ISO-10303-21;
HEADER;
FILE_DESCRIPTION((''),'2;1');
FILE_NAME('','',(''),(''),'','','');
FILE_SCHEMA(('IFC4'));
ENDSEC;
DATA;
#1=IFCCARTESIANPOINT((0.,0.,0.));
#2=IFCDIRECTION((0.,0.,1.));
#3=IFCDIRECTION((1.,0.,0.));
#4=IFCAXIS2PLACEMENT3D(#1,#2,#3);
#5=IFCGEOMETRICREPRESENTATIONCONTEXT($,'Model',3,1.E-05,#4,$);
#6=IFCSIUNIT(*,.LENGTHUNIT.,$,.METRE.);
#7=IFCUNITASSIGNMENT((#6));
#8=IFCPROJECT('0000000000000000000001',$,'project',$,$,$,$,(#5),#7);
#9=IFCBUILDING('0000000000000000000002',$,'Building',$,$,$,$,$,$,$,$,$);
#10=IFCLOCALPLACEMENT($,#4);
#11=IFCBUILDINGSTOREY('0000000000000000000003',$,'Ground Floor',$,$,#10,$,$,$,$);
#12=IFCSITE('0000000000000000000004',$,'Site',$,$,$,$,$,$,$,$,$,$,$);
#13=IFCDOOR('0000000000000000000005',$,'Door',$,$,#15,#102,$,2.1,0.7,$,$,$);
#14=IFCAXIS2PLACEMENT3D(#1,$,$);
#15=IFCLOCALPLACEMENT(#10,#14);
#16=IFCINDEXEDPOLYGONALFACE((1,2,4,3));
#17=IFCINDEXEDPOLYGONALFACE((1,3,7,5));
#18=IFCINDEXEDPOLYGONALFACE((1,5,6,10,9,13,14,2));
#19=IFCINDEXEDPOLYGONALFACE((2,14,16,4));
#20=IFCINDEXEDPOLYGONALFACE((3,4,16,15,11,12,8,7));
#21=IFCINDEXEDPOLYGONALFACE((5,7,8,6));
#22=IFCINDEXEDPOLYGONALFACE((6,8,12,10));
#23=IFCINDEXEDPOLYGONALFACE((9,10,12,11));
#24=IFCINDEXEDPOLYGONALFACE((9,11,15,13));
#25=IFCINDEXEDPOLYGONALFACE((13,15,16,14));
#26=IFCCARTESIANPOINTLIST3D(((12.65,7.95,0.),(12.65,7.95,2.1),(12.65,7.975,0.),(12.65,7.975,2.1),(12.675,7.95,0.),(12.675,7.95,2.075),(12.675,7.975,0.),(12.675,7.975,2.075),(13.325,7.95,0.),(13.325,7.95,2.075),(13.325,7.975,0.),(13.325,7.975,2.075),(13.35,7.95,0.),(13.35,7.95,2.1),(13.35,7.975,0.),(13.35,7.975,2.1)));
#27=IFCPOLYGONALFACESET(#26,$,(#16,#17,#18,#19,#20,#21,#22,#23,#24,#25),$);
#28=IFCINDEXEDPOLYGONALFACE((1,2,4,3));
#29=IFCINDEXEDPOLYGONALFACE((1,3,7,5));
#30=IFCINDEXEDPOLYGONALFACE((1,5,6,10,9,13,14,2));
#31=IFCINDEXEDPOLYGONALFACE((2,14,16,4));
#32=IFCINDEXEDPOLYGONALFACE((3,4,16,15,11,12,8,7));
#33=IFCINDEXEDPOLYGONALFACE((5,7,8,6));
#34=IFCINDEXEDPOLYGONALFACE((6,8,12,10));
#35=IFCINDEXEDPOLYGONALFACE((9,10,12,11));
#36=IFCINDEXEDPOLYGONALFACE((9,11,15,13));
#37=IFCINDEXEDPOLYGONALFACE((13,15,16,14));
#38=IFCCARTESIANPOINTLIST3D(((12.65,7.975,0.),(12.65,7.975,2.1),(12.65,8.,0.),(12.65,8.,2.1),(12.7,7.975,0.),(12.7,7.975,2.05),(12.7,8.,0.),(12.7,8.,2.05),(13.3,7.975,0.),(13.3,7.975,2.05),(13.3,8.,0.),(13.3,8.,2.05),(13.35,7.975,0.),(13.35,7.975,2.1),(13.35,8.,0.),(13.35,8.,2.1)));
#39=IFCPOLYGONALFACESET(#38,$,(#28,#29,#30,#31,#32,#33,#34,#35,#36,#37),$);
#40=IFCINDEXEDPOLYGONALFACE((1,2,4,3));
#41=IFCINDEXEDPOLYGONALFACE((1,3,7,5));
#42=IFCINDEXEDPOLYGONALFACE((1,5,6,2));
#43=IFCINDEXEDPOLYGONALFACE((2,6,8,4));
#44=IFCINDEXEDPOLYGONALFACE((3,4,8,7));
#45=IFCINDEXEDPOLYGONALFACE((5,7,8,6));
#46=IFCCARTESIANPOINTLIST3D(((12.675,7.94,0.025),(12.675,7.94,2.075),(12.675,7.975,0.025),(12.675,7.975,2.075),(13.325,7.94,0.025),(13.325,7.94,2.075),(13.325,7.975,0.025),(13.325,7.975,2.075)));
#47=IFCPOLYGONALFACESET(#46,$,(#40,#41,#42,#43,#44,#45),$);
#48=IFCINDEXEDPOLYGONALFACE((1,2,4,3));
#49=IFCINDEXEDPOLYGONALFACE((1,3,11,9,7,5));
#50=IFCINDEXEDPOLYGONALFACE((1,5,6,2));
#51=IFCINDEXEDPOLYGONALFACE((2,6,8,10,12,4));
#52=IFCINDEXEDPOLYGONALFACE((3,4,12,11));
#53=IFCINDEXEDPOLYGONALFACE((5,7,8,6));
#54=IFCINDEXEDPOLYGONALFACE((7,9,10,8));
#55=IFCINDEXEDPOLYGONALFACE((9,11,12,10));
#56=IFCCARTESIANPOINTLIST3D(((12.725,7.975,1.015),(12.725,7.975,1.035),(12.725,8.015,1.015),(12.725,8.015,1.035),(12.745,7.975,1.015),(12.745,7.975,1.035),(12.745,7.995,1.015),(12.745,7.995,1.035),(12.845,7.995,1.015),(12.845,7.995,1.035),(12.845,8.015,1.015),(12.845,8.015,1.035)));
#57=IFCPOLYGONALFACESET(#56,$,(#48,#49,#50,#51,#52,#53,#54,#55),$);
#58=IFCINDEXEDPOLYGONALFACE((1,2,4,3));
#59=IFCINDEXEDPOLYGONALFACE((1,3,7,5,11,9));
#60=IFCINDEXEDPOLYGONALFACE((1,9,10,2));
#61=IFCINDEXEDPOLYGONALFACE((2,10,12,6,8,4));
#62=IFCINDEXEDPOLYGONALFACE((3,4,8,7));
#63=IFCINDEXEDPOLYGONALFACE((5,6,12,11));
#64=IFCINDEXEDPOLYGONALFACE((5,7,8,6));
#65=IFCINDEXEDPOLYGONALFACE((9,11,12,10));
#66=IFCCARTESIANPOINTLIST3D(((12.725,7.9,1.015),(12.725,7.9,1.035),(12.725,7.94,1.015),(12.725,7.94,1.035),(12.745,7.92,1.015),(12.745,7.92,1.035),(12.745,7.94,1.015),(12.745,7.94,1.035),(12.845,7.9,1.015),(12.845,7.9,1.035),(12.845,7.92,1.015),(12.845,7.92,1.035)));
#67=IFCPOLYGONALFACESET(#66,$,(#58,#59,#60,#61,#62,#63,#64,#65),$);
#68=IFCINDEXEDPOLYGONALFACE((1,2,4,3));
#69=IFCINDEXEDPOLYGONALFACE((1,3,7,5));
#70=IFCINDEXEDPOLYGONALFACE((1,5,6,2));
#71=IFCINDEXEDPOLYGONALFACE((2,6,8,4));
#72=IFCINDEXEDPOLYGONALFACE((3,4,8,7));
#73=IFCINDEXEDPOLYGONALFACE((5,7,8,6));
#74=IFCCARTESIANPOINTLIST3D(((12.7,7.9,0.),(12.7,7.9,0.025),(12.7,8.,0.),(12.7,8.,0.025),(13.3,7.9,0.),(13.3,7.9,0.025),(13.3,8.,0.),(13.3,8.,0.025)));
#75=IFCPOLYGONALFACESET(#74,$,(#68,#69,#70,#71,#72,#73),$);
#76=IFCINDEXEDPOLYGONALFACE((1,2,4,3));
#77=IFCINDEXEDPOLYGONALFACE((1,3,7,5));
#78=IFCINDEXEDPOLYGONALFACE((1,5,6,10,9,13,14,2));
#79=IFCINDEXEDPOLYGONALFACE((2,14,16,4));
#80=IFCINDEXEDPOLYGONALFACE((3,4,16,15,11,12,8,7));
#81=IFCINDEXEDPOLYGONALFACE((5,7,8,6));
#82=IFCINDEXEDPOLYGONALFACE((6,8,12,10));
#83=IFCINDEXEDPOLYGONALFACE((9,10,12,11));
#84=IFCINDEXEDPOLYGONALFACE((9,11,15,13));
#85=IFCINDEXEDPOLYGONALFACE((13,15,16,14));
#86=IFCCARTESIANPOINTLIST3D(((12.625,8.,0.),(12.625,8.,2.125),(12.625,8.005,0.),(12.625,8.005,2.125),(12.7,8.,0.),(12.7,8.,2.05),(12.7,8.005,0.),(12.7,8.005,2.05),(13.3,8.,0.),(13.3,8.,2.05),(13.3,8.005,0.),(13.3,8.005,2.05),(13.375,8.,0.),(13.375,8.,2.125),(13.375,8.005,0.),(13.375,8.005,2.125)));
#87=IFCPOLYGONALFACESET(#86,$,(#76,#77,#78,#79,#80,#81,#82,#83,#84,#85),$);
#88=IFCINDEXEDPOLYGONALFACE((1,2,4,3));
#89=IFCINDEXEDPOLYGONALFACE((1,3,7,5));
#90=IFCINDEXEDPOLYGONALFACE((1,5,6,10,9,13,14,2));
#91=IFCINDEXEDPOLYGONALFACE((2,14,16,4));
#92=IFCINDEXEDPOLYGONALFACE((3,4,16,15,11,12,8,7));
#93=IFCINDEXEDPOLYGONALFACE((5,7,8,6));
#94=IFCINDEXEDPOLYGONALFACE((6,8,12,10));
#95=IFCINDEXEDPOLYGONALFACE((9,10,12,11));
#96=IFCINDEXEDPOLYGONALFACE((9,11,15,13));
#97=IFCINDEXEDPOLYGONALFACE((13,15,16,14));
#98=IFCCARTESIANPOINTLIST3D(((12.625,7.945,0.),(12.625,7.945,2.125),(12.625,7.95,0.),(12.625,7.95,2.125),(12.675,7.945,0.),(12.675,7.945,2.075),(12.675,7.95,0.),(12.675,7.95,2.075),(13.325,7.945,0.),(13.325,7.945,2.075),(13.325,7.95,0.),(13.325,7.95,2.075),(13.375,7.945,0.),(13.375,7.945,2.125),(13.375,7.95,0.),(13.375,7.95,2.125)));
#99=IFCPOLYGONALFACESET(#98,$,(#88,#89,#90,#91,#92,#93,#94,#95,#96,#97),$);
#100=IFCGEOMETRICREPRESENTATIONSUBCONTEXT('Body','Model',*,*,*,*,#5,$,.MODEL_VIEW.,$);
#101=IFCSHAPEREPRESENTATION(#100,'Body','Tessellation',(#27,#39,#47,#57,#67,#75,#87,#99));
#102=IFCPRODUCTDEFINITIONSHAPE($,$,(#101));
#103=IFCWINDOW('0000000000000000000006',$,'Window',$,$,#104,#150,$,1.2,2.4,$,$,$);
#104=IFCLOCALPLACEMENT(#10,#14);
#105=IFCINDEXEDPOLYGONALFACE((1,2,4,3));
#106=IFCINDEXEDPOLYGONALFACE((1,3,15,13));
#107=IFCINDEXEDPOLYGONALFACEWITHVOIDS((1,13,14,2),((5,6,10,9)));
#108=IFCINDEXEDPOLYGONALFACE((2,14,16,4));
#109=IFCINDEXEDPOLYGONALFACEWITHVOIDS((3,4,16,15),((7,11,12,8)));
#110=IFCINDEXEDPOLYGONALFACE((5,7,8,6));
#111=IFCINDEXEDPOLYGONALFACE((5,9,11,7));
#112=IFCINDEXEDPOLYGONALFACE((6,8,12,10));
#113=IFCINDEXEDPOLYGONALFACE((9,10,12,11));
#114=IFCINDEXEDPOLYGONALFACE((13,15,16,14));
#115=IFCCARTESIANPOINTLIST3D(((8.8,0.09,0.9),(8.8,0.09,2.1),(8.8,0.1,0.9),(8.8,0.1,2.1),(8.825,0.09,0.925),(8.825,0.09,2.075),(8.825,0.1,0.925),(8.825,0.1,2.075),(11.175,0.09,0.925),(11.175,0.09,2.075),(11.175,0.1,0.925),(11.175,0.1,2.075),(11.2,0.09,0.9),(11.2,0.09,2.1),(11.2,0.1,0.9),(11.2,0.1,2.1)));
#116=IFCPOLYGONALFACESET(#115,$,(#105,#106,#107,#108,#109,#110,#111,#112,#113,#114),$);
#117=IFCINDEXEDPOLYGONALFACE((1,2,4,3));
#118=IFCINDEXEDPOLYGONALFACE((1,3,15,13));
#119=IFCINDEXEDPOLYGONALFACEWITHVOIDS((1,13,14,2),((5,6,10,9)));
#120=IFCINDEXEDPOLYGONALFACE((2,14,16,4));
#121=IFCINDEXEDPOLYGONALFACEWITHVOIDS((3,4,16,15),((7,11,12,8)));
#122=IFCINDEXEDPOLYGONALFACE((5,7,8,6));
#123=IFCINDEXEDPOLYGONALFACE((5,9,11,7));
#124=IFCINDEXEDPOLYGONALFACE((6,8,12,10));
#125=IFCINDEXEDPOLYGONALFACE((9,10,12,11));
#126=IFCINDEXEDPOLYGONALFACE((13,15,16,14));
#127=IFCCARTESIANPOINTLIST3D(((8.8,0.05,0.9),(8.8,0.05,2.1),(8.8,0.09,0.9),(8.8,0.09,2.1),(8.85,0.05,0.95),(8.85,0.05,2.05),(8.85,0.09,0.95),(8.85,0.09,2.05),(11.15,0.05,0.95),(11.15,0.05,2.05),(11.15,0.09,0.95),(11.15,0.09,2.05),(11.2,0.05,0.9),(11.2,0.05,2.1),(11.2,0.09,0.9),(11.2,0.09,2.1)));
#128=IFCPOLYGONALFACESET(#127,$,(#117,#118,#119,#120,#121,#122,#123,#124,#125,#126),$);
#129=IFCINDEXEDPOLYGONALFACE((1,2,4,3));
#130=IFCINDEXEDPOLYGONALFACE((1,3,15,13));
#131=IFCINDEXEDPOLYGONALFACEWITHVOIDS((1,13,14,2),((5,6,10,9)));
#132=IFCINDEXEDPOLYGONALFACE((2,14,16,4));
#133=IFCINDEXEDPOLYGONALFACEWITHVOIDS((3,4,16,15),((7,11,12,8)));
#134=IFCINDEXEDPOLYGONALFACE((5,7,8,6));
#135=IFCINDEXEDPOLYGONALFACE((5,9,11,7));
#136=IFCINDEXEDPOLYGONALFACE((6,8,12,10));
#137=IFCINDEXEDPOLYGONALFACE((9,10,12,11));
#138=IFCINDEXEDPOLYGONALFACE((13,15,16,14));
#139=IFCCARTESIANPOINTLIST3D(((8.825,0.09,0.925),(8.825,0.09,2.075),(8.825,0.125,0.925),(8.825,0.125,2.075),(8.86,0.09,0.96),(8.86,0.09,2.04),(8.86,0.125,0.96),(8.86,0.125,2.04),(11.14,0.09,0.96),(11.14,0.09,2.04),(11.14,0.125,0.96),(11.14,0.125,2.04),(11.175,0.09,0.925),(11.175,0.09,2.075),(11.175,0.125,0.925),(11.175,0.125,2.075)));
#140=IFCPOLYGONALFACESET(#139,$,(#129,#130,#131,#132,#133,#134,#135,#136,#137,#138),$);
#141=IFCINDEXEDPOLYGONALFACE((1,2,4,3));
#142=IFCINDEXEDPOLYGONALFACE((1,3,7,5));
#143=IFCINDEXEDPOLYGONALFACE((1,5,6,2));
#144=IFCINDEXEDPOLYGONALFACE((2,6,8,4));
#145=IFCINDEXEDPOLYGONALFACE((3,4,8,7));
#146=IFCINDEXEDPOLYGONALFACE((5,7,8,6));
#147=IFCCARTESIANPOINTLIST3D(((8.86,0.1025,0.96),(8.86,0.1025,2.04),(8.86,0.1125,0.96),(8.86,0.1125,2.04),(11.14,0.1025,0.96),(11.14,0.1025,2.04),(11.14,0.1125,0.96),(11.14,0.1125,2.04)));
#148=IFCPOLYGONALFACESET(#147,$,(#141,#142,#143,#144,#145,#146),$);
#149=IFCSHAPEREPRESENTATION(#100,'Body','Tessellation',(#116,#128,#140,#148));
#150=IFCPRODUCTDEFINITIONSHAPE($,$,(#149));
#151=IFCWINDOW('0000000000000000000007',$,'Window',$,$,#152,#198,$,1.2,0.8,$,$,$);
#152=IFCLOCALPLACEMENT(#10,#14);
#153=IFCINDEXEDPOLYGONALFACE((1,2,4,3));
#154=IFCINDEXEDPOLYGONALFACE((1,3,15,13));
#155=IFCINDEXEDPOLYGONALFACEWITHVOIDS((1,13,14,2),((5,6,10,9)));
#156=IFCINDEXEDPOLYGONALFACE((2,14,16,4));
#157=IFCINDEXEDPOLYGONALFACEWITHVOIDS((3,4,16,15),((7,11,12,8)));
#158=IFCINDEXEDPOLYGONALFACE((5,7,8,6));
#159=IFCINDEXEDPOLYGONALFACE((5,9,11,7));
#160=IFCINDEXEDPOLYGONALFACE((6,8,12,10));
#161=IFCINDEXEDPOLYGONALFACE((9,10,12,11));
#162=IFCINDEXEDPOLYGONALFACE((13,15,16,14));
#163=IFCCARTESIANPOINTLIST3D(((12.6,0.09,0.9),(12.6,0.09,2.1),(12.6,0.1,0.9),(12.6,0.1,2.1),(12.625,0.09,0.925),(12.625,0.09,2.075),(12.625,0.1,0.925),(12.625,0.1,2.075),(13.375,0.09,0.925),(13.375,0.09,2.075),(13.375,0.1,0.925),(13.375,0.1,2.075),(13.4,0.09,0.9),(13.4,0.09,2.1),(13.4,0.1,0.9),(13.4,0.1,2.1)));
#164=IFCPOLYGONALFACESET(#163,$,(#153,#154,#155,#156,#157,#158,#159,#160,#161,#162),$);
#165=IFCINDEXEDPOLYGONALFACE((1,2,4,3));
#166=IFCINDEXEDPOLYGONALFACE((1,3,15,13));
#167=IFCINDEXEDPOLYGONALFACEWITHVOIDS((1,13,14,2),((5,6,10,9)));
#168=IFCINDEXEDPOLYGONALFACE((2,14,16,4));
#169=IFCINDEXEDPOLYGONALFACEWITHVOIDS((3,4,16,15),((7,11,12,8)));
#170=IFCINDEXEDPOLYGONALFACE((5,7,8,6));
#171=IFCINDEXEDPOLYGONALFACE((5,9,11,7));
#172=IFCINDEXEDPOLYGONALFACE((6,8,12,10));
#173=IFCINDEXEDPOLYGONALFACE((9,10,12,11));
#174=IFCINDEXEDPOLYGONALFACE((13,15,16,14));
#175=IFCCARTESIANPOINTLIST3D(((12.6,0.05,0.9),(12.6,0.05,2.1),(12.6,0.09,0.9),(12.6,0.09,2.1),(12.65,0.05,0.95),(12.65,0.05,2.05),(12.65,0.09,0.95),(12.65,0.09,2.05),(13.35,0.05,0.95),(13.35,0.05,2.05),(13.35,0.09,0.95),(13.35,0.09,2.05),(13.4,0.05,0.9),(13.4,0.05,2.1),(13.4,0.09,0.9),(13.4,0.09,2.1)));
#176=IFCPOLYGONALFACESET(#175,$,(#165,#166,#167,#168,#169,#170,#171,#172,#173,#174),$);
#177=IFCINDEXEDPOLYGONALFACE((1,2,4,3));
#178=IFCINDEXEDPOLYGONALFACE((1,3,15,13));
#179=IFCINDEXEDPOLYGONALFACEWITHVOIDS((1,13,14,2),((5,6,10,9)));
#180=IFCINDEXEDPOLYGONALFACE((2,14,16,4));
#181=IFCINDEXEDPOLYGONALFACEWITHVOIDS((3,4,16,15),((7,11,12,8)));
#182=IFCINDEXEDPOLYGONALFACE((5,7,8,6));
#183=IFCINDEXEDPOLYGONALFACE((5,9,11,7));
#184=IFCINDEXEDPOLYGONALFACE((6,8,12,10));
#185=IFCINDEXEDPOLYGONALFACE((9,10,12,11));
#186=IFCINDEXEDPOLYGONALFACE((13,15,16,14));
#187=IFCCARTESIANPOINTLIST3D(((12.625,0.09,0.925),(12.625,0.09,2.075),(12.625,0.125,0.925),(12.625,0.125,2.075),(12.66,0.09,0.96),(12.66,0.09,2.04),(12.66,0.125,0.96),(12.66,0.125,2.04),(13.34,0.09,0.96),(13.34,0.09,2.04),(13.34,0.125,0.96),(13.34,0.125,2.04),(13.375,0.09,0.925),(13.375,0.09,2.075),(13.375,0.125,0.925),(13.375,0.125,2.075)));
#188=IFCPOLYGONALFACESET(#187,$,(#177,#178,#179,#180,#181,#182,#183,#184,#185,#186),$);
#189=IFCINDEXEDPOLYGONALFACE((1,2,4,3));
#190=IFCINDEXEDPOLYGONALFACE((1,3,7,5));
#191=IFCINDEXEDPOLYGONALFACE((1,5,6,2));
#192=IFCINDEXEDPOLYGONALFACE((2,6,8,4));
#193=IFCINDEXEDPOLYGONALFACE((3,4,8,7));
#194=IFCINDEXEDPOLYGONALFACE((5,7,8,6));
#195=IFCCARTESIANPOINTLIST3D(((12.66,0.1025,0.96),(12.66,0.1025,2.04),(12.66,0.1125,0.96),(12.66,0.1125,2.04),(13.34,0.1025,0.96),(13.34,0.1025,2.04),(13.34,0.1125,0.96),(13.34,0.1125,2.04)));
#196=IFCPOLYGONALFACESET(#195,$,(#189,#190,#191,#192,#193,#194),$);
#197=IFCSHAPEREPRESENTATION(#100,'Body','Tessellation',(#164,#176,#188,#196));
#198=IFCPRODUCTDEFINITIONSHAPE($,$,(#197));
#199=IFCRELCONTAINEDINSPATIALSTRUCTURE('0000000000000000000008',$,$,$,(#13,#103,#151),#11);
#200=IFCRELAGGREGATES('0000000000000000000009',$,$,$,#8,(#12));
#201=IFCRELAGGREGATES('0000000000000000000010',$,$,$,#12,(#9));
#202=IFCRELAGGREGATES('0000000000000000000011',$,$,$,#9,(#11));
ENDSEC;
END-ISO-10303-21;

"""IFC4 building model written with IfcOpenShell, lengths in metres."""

from ifc_helpers import new_model, si_unit, frame, origin_with_axes, place, context, subcontext, project, spatial, line, indexed_curve, outline, extrude, element, save


model = new_model("IFC4")

# Units and contexts
model_context = context("Model", 3, precision=1e-05, world=origin_with_axes())
body_context = subcontext(model_context, "Body", "Model", "MODEL_VIEW")
ifc_project = project(units=[si_unit("LENGTHUNIT", "METRE")], contexts=[model_context])

# Site, building, storey
site = spatial("IfcSite", under=ifc_project, Name="Site")
building = spatial("IfcBuilding", under=site, Name="Building")
storey_placement = place(None, origin_with_axes())
storey = spatial("IfcBuildingStorey", under=building, at=storey_placement, Name="Ground Floor")

# Door
door_1_placement = place(storey_placement, frame((13.35, 8.0, 0.0), z_axis=(0.0, 0.0, 1.0), x_axis=(-1.0, 0.0, 0.0)))
element("IfcDoor", 1, at=door_1_placement, inside=storey, Name="Door", OverallHeight=2.1, OverallWidth=0.7, context=body_context, shape_type="SweptSolid", body=[
    extrude(outline(indexed_curve([(0.0, 0.0), (0.0, 2.1), (0.7, 2.1), (0.7, 0.0), (0.675, 0.0), (0.675, 2.075), (0.025, 2.075), (0.025, 0.0)], segments=[line(1, 2, 3, 4, 5, 6, 7, 8, 1)])), frame((0.0, 0.025, 0.0), z_axis=(0.0, -1.0, 0.0), x_axis=(1.0, 0.0, 0.0)), (0.0, 0.0, -1.0), 0.025),
    extrude(outline(indexed_curve([(0.0, 0.0), (0.0, 2.1), (0.7, 2.1), (0.7, 0.0), (0.65, 0.0), (0.65, 2.05), (0.05, 2.05), (0.05, 0.0)], segments=[line(1, 2, 3, 4, 5, 6, 7, 8, 1)])), frame((0.0, 0.0, 0.0), z_axis=(0.0, -1.0, 0.0), x_axis=(1.0, 0.0, 0.0)), (0.0, 0.0, -1.0), 0.025),
    extrude(outline(indexed_curve([(0.0, 0.0), (0.65, 0.0), (0.65, 0.035), (0.0, 0.035)], segments=[line(1, 2, 3, 4, 1)])), frame((0.025, 0.025, 0.025), z_axis=(0.0, 0.0, 1.0), x_axis=(1.0, 0.0, 0.0)), (0.0, 0.0, 1.0), 2.05),
    extrude(outline(indexed_curve([(0.0, 0.0), (0.0, -0.04), (-0.12, -0.04), (-0.12, -0.02), (-0.02, -0.02), (-0.02, 0.0)], segments=[line(1, 2, 3, 4, 5, 6, 1)])), frame((0.625, 0.025, 1.015), z_axis=(0.0, 0.0, 1.0), x_axis=(1.0, 0.0, 0.0)), (0.0, 0.0, 1.0), 0.02),
    extrude(outline(indexed_curve([(0.0, 0.0), (0.0, 0.04), (-0.12, 0.04), (-0.12, 0.02), (-0.02, 0.02), (-0.02, 0.0)], segments=[line(1, 2, 3, 4, 5, 6, 1)])), frame((0.625, 0.06, 1.015), z_axis=(0.0, 0.0, 1.0), x_axis=(1.0, 0.0, 0.0)), (0.0, 0.0, 1.0), 0.02),
    extrude(outline(indexed_curve([(0.0, 0.0), (0.6, 0.0), (0.6, 0.1), (0.0, 0.1)], segments=[line(1, 2, 3, 4, 1)])), frame((0.05, 0.0, 0.0), z_axis=(0.0, 0.0, 1.0), x_axis=(1.0, 0.0, 0.0)), (0.0, 0.0, 1.0), 0.025),
    extrude(outline(indexed_curve([(0.0, 0.0), (0.0, 2.125), (0.75, 2.125), (0.75, 0.0), (0.675, 0.0), (0.675, 2.05), (0.075, 2.05), (0.075, 0.0)], segments=[line(1, 2, 3, 4, 5, 6, 7, 8, 1)])), frame((-0.025, -0.005, 0.0), z_axis=(0.0, -1.0, 0.0), x_axis=(1.0, 0.0, 0.0)), (0.0, 0.0, -1.0), 0.005),
    extrude(outline(indexed_curve([(0.0, 0.0), (0.0, 2.125), (0.75, 2.125), (0.75, 0.0), (0.7, 0.0), (0.7, 2.075), (0.05, 2.075), (0.05, 0.0)], segments=[line(1, 2, 3, 4, 5, 6, 7, 8, 1)])), frame((-0.025, 0.05, 0.0), z_axis=(0.0, -1.0, 0.0), x_axis=(1.0, 0.0, 0.0)), (0.0, 0.0, -1.0), 0.005),
])

# Windows
window_1_placement = place(storey_placement, frame((8.8, 0.0, 0.9), z_axis=(0.0, 0.0, 1.0), x_axis=(1.0, 0.0, 0.0)))
element("IfcWindow", 2, at=window_1_placement, inside=storey, Name="Window", OverallHeight=1.2, OverallWidth=2.4, context=body_context, shape_type="SweptSolid", body=[
    extrude(outline(indexed_curve([(0.0, 0.0), (2.4, 0.0), (2.4, 1.2), (0.0, 1.2)], segments=[line(1, 2, 3, 4, 1)]), holes=[indexed_curve([(0.025, 0.025), (2.375, 0.025), (2.375, 1.175), (0.025, 1.175)], segments=[line(1, 2, 3, 4, 1)])]), frame((0.0, 0.09, 0.0), z_axis=(0.0, -1.0, 0.0), x_axis=(1.0, 0.0, 0.0)), (0.0, 0.0, -1.0), 0.01),
    extrude(outline(indexed_curve([(0.0, 0.0), (2.4, 0.0), (2.4, 1.2), (0.0, 1.2)], segments=[line(1, 2, 3, 4, 1)]), holes=[indexed_curve([(0.05, 0.05), (2.35, 0.05), (2.35, 1.15), (0.05, 1.15)], segments=[line(1, 2, 3, 4, 1)])]), frame((0.0, 0.05, 0.0), z_axis=(0.0, -1.0, 0.0), x_axis=(1.0, 0.0, 0.0)), (0.0, 0.0, -1.0), 0.04),
    extrude(outline(indexed_curve([(0.0, 0.0), (2.35, 0.0), (2.35, 1.15), (0.0, 1.15)], segments=[line(1, 2, 3, 4, 1)]), holes=[indexed_curve([(0.035, 0.035), (2.315, 0.035), (2.315, 1.115), (0.035, 1.115)], segments=[line(1, 2, 3, 4, 1)])]), frame((0.025, 0.09, 0.025), z_axis=(0.0, -1.0, 0.0), x_axis=(1.0, 0.0, 0.0)), (0.0, 0.0, -1.0), 0.035),
    extrude(outline(indexed_curve([(0.035, 0.035), (2.315, 0.035), (2.315, 1.115), (0.035, 1.115)], segments=[line(1, 2, 3, 4, 1)])), frame((0.025, 0.1025, 0.025), z_axis=(0.0, -1.0, 0.0), x_axis=(1.0, 0.0, 0.0)), (0.0, 0.0, -1.0), 0.01),
])
window_2_placement = place(storey_placement, frame((12.6, 0.0, 0.9), z_axis=(0.0, 0.0, 1.0), x_axis=(1.0, 0.0, 0.0)))
element("IfcWindow", 3, at=window_2_placement, inside=storey, Name="Window", OverallHeight=1.2, OverallWidth=0.8, context=body_context, shape_type="SweptSolid", body=[
    extrude(outline(indexed_curve([(0.0, 0.0), (0.8, 0.0), (0.8, 1.2), (0.0, 1.2)], segments=[line(1, 2, 3, 4, 1)]), holes=[indexed_curve([(0.025, 0.025), (0.775, 0.025), (0.775, 1.175), (0.025, 1.175)], segments=[line(1, 2, 3, 4, 1)])]), frame((0.0, 0.09, 0.0), z_axis=(0.0, -1.0, 0.0), x_axis=(1.0, 0.0, 0.0)), (0.0, 0.0, -1.0), 0.01),
    extrude(outline(indexed_curve([(0.0, 0.0), (0.8, 0.0), (0.8, 1.2), (0.0, 1.2)], segments=[line(1, 2, 3, 4, 1)]), holes=[indexed_curve([(0.05, 0.05), (0.75, 0.05), (0.75, 1.15), (0.05, 1.15)], segments=[line(1, 2, 3, 4, 1)])]), frame((0.0, 0.05, 0.0), z_axis=(0.0, -1.0, 0.0), x_axis=(1.0, 0.0, 0.0)), (0.0, 0.0, -1.0), 0.04),
    extrude(outline(indexed_curve([(0.0, 0.0), (0.75, 0.0), (0.75, 1.15), (0.0, 1.15)], segments=[line(1, 2, 3, 4, 1)]), holes=[indexed_curve([(0.035, 0.035), (0.715, 0.035), (0.715, 1.115), (0.035, 1.115)], segments=[line(1, 2, 3, 4, 1)])]), frame((0.025, 0.09, 0.025), z_axis=(0.0, -1.0, 0.0), x_axis=(1.0, 0.0, 0.0)), (0.0, 0.0, -1.0), 0.035),
    extrude(outline(indexed_curve([(0.035, 0.035), (0.715, 0.035), (0.715, 1.115), (0.035, 1.115)], segments=[line(1, 2, 3, 4, 1)])), frame((0.025, 0.1025, 0.025), z_axis=(0.0, -1.0, 0.0), x_axis=(1.0, 0.0, 0.0)), (0.0, 0.0, -1.0), 0.01),
])

save(model, "model.ifc")
